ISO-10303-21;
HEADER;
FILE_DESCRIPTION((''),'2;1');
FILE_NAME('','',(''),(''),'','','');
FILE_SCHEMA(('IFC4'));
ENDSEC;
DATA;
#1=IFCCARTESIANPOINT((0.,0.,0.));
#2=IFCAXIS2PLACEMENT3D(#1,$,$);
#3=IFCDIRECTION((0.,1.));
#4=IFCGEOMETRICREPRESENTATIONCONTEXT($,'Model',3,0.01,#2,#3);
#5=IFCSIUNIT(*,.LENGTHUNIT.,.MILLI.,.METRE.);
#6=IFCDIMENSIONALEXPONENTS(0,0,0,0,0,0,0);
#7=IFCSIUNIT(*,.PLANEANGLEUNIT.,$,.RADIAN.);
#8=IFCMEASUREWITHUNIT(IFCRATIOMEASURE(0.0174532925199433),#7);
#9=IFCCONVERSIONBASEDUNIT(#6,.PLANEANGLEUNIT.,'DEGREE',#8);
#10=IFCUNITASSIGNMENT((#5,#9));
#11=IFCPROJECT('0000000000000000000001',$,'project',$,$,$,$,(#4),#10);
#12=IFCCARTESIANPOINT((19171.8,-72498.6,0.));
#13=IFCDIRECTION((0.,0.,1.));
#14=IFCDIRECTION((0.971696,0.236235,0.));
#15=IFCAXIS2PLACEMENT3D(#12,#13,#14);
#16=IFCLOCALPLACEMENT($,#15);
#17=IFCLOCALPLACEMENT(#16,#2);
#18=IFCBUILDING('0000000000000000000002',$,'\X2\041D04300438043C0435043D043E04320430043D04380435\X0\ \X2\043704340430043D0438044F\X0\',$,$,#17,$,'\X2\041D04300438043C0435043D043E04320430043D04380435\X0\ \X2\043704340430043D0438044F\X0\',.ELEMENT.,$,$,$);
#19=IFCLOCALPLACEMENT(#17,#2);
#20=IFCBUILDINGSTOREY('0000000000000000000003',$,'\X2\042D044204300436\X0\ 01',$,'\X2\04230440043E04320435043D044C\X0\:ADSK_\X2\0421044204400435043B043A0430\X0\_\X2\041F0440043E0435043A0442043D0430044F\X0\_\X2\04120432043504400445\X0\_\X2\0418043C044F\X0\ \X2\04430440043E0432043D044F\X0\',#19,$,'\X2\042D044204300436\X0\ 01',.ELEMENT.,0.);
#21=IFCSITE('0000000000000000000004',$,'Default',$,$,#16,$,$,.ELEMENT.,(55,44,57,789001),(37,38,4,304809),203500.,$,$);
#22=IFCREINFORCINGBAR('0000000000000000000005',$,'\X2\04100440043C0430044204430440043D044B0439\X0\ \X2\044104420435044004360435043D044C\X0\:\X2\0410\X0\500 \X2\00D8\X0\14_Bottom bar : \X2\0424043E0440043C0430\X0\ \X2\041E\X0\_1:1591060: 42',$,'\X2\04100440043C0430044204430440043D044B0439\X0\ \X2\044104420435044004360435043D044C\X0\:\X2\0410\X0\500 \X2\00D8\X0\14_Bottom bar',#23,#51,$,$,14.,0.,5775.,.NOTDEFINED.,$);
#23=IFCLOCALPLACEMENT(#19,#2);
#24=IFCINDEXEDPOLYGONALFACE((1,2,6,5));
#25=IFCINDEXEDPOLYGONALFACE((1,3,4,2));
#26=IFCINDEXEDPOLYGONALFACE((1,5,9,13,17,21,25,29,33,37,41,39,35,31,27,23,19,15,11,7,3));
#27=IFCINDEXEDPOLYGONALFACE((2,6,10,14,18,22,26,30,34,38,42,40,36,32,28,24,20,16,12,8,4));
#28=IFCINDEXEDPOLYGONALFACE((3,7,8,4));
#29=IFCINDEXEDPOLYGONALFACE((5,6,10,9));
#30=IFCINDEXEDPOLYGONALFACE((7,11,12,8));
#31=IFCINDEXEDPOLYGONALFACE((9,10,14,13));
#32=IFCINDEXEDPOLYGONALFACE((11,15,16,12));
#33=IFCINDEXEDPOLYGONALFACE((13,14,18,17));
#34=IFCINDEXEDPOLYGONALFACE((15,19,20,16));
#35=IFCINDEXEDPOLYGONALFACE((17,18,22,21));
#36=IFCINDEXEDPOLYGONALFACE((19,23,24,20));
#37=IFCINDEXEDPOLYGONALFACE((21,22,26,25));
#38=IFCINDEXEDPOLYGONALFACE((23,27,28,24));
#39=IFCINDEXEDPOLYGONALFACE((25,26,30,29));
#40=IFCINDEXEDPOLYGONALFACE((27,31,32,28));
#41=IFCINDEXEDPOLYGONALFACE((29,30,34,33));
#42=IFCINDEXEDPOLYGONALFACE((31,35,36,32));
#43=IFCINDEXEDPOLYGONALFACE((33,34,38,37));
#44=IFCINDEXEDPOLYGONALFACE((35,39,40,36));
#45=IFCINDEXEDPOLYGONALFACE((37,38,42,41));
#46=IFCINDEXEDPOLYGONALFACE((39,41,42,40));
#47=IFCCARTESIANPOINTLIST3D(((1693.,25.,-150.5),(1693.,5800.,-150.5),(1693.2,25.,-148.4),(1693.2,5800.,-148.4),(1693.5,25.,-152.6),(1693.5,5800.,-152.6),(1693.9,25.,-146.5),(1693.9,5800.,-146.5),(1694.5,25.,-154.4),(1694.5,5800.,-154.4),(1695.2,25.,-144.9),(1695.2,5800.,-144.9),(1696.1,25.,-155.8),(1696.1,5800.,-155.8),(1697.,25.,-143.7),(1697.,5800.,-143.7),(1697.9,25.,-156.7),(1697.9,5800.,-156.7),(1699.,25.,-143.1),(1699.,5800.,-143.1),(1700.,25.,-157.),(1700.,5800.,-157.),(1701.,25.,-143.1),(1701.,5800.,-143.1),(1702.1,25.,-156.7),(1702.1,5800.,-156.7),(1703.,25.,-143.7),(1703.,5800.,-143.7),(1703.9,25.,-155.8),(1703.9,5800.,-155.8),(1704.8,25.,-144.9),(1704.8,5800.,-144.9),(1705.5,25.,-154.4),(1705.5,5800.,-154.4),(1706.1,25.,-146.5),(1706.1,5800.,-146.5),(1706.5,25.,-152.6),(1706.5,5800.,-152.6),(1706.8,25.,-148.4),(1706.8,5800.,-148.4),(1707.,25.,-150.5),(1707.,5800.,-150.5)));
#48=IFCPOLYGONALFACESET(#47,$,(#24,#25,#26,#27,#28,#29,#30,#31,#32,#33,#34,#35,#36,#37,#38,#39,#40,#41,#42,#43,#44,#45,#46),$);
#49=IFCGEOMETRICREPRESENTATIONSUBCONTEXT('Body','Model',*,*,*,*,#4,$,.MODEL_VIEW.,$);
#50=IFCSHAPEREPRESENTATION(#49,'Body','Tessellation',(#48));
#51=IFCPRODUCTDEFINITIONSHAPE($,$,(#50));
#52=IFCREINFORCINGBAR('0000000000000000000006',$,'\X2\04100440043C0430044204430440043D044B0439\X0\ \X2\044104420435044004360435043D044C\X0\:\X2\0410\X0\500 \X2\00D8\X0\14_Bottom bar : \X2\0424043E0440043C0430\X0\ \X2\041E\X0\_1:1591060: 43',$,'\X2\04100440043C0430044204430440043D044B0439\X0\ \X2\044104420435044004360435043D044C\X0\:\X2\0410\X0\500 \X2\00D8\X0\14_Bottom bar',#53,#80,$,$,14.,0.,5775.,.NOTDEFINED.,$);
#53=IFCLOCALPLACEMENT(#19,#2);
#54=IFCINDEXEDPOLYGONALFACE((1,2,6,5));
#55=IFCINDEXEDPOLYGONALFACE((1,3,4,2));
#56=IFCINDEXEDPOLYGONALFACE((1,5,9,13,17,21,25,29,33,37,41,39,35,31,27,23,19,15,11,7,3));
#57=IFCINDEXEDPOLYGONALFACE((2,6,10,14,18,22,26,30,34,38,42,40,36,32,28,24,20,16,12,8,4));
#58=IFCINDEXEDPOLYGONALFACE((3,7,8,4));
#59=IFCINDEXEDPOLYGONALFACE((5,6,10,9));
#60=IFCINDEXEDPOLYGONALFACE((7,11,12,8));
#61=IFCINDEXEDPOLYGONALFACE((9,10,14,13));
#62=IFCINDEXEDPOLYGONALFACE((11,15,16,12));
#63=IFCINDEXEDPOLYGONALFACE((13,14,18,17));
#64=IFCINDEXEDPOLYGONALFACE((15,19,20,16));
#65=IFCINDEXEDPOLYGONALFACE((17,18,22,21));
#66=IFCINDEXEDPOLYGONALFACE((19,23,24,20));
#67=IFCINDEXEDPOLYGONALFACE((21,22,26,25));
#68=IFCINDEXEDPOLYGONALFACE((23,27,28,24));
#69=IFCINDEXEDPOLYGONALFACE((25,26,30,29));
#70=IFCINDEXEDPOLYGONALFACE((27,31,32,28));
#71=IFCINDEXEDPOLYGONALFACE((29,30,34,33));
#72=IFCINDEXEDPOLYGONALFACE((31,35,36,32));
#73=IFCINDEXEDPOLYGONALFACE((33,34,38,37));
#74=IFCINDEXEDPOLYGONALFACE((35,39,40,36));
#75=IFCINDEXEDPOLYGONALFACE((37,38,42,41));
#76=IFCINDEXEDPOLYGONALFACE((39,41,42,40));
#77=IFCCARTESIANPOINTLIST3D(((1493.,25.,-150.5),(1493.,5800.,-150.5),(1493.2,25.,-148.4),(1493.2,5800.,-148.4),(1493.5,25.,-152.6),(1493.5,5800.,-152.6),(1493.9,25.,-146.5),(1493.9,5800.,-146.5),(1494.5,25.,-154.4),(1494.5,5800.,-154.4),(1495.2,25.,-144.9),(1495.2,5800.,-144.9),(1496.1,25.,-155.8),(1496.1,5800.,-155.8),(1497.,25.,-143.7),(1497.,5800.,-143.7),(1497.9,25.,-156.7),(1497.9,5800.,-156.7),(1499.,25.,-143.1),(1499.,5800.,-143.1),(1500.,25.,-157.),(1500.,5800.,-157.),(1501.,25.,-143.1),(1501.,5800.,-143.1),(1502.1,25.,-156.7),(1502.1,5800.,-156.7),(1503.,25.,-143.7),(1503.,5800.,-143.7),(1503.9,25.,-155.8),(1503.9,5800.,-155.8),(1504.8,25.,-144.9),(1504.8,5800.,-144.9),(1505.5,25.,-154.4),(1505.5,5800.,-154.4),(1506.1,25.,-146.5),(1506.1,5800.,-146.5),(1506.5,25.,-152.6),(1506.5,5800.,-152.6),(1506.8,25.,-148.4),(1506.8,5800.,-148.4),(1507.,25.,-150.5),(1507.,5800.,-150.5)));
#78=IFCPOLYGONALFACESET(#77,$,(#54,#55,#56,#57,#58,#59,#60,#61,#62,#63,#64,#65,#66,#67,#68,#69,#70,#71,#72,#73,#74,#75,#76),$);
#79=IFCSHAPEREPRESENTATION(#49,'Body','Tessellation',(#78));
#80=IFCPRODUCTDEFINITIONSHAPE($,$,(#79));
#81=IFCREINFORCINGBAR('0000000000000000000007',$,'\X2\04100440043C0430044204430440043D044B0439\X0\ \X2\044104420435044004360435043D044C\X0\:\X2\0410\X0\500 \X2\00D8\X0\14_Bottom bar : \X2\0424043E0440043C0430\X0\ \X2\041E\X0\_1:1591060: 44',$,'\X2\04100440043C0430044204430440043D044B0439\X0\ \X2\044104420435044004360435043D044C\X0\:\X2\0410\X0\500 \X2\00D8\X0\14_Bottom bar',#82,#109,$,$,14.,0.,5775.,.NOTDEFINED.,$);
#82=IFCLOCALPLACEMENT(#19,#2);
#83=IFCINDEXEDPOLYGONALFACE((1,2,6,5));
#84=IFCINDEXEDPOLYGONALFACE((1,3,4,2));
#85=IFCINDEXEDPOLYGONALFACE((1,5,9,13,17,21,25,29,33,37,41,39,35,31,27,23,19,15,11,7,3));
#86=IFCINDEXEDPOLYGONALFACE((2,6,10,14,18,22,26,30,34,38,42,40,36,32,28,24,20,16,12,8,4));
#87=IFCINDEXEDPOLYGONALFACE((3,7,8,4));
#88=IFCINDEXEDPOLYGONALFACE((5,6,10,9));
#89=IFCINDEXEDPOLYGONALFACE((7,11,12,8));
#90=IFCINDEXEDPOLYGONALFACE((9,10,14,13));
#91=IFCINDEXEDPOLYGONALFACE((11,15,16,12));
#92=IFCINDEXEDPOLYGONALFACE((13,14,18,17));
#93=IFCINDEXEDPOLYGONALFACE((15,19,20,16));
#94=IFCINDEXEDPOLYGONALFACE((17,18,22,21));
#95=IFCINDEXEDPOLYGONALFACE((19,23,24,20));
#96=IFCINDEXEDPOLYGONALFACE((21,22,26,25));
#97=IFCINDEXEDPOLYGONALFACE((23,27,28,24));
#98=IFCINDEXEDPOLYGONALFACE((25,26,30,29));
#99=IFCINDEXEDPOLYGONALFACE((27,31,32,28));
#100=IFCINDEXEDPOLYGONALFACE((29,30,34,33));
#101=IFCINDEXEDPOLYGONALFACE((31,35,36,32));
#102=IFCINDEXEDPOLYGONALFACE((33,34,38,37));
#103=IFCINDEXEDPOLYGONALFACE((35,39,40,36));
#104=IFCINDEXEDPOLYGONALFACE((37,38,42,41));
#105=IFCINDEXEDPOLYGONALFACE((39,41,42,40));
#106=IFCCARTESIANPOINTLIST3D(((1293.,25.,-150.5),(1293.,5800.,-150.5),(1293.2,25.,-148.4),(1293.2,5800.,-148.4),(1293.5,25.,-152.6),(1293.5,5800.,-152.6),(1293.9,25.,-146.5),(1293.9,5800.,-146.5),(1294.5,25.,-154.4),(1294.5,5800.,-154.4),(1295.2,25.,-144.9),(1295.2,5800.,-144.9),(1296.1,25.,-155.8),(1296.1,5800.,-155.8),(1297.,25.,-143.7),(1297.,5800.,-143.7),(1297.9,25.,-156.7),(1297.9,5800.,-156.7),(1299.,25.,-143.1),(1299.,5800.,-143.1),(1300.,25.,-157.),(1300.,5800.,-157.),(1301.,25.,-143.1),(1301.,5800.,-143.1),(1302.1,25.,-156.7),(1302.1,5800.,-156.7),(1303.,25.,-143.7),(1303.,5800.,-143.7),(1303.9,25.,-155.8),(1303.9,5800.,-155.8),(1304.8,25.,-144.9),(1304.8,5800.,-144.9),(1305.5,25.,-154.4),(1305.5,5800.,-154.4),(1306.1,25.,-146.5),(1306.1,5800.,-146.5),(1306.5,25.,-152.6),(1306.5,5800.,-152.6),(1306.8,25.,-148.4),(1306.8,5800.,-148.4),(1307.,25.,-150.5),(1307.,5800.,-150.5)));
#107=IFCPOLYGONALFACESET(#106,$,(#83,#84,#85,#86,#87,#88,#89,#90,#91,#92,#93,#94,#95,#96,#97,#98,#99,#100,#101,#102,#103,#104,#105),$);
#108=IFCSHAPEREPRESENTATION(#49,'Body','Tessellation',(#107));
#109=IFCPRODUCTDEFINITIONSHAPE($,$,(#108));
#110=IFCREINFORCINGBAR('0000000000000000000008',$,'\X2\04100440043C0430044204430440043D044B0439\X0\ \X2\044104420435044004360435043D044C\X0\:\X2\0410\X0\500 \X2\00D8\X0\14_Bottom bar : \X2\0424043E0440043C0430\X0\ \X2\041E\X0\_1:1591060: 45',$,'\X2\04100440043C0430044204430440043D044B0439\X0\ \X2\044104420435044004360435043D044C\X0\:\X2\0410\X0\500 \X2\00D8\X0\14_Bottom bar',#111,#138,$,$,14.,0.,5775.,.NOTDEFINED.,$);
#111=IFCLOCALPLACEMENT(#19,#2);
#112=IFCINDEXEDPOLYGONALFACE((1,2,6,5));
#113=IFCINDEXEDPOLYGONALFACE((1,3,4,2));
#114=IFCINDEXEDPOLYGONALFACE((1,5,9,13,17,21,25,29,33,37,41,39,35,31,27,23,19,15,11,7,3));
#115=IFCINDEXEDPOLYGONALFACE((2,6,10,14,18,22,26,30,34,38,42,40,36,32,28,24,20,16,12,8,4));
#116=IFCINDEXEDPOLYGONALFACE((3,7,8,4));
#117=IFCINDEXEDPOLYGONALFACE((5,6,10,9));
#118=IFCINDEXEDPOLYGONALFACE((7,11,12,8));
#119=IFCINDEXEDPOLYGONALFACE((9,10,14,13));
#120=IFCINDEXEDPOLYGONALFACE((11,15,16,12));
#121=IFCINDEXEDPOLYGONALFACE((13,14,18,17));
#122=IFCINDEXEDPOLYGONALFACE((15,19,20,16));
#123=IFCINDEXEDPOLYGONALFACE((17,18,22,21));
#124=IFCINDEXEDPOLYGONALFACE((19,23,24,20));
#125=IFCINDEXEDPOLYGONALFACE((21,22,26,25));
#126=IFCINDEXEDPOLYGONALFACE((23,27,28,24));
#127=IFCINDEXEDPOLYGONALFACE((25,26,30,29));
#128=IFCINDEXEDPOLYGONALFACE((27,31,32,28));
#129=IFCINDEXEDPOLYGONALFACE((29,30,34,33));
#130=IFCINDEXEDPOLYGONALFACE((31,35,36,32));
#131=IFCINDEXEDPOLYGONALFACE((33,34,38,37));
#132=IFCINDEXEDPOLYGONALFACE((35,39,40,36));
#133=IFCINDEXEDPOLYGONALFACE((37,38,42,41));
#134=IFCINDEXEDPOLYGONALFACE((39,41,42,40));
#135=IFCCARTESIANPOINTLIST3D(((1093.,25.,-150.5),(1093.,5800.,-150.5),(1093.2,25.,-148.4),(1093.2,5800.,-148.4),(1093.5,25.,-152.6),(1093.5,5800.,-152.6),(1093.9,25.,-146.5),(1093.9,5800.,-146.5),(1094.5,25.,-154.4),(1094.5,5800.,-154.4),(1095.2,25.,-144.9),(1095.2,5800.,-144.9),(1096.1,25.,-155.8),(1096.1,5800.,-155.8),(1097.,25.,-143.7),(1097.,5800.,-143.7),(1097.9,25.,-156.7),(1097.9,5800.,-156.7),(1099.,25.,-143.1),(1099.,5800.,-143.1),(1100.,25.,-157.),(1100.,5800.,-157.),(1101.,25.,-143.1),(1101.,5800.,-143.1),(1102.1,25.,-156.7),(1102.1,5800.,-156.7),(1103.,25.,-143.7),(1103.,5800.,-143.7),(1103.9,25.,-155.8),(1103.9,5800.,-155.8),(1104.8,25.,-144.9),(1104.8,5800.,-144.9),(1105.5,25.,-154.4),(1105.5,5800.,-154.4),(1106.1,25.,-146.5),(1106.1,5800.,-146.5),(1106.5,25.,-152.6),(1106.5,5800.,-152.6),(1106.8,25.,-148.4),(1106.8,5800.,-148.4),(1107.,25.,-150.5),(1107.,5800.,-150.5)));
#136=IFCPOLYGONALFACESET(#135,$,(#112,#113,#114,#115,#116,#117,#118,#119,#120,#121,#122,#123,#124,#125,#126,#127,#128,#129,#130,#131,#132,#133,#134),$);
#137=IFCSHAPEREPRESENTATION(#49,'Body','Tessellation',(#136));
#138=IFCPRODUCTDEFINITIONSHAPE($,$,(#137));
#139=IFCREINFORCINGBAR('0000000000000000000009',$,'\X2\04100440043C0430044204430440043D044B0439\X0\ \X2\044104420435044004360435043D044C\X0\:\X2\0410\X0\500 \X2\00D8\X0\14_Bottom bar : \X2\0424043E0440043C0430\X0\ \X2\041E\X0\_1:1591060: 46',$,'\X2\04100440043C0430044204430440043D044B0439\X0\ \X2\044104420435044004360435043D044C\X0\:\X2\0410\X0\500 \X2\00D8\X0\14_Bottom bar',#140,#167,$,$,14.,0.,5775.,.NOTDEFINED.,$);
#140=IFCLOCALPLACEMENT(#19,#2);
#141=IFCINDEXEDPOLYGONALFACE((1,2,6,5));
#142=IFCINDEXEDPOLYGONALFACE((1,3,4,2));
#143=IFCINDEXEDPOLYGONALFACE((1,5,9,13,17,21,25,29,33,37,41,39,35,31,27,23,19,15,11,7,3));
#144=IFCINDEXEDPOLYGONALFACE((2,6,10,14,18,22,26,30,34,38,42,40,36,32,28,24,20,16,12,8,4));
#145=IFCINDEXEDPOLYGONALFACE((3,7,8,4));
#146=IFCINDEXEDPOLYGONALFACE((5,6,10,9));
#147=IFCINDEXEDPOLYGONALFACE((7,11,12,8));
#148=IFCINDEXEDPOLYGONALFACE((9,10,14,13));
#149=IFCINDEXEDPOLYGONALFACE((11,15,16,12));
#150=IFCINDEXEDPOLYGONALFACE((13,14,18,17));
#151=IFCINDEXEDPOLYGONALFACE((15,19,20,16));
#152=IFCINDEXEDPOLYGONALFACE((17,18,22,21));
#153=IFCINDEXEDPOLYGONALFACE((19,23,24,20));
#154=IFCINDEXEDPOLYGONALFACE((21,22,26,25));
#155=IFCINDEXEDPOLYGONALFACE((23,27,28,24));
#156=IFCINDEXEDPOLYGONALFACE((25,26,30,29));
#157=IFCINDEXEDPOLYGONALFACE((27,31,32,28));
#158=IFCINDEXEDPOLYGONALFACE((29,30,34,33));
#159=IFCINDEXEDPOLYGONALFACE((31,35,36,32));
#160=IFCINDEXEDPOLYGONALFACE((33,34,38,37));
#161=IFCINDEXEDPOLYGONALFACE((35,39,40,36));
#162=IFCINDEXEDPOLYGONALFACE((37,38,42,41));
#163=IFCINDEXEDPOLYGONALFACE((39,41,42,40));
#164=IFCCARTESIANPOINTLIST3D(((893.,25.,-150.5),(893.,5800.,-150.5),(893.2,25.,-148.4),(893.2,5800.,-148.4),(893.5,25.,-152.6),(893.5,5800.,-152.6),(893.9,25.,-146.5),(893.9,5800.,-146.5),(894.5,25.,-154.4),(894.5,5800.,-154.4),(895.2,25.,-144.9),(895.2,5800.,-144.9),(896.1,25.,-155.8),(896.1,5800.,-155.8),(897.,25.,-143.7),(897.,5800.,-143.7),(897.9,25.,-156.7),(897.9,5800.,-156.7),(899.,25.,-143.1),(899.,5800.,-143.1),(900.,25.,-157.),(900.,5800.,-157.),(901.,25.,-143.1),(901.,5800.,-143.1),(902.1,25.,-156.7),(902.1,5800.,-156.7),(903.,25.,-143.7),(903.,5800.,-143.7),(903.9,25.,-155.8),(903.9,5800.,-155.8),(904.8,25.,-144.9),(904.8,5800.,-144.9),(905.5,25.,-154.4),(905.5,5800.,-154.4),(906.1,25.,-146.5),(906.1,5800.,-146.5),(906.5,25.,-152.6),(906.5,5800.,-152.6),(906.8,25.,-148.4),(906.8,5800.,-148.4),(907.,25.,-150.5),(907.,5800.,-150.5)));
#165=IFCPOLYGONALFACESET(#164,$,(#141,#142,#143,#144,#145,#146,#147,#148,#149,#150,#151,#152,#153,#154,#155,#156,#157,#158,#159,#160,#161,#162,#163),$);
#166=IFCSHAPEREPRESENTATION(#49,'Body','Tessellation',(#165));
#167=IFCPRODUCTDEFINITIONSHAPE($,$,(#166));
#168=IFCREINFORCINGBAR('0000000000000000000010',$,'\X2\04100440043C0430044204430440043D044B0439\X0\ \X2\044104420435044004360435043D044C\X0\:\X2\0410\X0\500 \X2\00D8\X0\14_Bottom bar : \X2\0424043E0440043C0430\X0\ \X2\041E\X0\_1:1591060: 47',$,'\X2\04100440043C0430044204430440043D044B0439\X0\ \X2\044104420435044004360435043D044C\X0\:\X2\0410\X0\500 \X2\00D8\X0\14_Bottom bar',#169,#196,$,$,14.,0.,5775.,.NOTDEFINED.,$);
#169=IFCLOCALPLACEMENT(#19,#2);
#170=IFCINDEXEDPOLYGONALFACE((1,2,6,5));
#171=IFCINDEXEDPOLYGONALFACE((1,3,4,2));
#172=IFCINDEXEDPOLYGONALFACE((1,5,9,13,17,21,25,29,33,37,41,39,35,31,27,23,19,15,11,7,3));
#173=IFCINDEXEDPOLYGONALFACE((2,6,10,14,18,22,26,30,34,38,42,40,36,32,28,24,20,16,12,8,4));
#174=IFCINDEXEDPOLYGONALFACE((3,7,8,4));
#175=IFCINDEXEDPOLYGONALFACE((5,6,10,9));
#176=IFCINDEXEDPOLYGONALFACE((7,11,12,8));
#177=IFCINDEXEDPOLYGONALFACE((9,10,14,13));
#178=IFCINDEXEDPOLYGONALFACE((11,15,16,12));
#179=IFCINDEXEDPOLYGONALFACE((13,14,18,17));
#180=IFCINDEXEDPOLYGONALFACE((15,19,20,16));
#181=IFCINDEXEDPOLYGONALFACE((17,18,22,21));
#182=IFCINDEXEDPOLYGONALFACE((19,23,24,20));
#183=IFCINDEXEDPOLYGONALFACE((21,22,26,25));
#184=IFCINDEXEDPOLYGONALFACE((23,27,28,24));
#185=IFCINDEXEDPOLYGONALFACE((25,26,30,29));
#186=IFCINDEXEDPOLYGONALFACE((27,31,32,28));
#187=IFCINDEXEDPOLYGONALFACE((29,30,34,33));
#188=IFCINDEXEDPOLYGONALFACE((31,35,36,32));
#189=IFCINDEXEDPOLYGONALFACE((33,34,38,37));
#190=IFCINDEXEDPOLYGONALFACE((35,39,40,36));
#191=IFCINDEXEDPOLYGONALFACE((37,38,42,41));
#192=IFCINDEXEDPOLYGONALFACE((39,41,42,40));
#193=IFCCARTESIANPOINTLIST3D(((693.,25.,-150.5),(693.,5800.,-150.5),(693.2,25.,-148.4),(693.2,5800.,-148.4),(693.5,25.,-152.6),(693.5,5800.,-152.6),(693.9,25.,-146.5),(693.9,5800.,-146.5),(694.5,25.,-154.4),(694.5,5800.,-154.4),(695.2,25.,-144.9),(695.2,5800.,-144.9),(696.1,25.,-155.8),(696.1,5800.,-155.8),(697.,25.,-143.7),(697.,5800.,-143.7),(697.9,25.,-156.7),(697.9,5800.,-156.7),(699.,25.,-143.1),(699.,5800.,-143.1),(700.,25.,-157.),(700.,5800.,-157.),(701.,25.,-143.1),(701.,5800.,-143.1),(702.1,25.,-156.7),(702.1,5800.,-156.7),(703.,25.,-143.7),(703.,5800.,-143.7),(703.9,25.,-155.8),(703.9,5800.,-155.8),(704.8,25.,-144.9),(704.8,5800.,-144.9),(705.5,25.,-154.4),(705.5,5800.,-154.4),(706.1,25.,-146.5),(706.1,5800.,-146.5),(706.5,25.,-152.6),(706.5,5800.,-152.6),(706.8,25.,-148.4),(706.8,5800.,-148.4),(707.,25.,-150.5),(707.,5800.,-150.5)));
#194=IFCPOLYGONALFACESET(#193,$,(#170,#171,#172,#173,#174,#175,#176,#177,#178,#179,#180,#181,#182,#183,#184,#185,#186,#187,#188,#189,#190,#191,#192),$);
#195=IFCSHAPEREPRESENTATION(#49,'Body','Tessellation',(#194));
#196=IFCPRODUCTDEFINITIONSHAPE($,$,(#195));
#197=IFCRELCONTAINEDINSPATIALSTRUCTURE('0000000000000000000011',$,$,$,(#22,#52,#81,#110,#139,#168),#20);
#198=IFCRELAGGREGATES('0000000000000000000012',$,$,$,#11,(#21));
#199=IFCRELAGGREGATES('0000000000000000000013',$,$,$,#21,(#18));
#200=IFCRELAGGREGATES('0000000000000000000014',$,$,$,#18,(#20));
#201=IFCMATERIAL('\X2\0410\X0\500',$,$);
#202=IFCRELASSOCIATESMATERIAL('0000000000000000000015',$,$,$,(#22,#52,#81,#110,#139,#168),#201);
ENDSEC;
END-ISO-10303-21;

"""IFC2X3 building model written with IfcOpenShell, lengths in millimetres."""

from ifc_helpers import new_model, entity, si_unit, converted_unit, direction, frame, origin, place, context, subcontext, project, spatial, material, element, save


model = new_model("IFC2X3")

# Units and contexts
model_context = context("Model", 3, precision=0.01, world=origin(), true_north=direction((0.0, 1.0)))
body_context = subcontext(model_context, "Body", "Model", "MODEL_VIEW")
ifc_project = project(units=[si_unit("LENGTHUNIT", "METRE", prefix="MILLI"), converted_unit("PLANEANGLEUNIT", "DEGREE", entity("IfcRatioMeasure", 0.0174532925199433), si_unit("PLANEANGLEUNIT", "RADIAN"), dimensions=[0, 0, 0, 0, 0, 0, 0])], contexts=[model_context])

# Site, building, storey
site_placement = place(None, frame((19171.8, -72498.6, 0.0), z_axis=(0.0, 0.0, 1.0), x_axis=(0.971696, 0.236235, 0.0)))
site = spatial("IfcSite", under=ifc_project, at=site_placement, Name="Default", CompositionType="ELEMENT", RefLatitude=(55, 44, 57, 789001), RefLongitude=(37, 38, 4, 304809), RefElevation=203500.0)
building_placement = place(site_placement, origin())
building = spatial("IfcBuilding", under=site, at=building_placement, Name="Наименование здания", LongName="Наименование здания", CompositionType="ELEMENT")
storey_placement = place(building_placement, origin())
storey = spatial("IfcBuildingStorey", under=building, at=storey_placement, Name="Этаж 01", ObjectType="Уровень:ADSK_Стрелка_Проектная_Вверх_Имя уровня", LongName="Этаж 01", CompositionType="ELEMENT", Elevation=0.0)

# Reinforcing bars
ifc_material = material(Name="А500")
placement = place(storey_placement, origin())
element("IfcReinforcingBar", 1, at=placement, inside=storey, material=ifc_material, Name="Арматурный стержень:А500 Ø14_Bottom bar : Форма О_1:1591060: 42", ObjectType="Арматурный стержень:А500 Ø14_Bottom bar", BarLength=5775.0, BarRole="NOTDEFINED", CrossSectionArea=0.0, NominalDiameter=14.0, context=body_context, shape_type="AdvancedSweptSolid", body=[
    entity("IfcSweptDiskSolid", entity("IfcCompositeCurve", [entity("IfcCompositeCurveSegment", "CONTINUOUS", True, entity("IfcPolyline", [entity("IfcCartesianPoint", [1700.0, 5800.0, -150.0]), entity("IfcCartesianPoint", [1700.0, 25.0, -150.0])]))], False), 7.0, None, 0.0, 1.0),
])
element("IfcReinforcingBar", 2, at=placement, inside=storey, material=ifc_material, Name="Арматурный стержень:А500 Ø14_Bottom bar : Форма О_1:1591060: 43", ObjectType="Арматурный стержень:А500 Ø14_Bottom bar", BarLength=5775.0, BarRole="NOTDEFINED", CrossSectionArea=0.0, NominalDiameter=14.0, context=body_context, shape_type="AdvancedSweptSolid", body=[
    entity("IfcSweptDiskSolid", entity("IfcCompositeCurve", [entity("IfcCompositeCurveSegment", "CONTINUOUS", True, entity("IfcPolyline", [entity("IfcCartesianPoint", [1500.0, 5800.0, -150.0]), entity("IfcCartesianPoint", [1500.0, 25.0, -150.0])]))], False), 7.0, None, 0.0, 1.0),
])
element("IfcReinforcingBar", 3, at=placement, inside=storey, material=ifc_material, Name="Арматурный стержень:А500 Ø14_Bottom bar : Форма О_1:1591060: 44", ObjectType="Арматурный стержень:А500 Ø14_Bottom bar", BarLength=5775.0, BarRole="NOTDEFINED", CrossSectionArea=0.0, NominalDiameter=14.0, context=body_context, shape_type="AdvancedSweptSolid", body=[
    entity("IfcSweptDiskSolid", entity("IfcCompositeCurve", [entity("IfcCompositeCurveSegment", "CONTINUOUS", True, entity("IfcPolyline", [entity("IfcCartesianPoint", [1300.0, 5800.0, -150.0]), entity("IfcCartesianPoint", [1300.0, 25.0, -150.0])]))], False), 7.0, None, 0.0, 1.0),
])
element("IfcReinforcingBar", 4, at=placement, inside=storey, material=ifc_material, Name="Арматурный стержень:А500 Ø14_Bottom bar : Форма О_1:1591060: 45", ObjectType="Арматурный стержень:А500 Ø14_Bottom bar", BarLength=5775.0, BarRole="NOTDEFINED", CrossSectionArea=0.0, NominalDiameter=14.0, context=body_context, shape_type="AdvancedSweptSolid", body=[
    entity("IfcSweptDiskSolid", entity("IfcCompositeCurve", [entity("IfcCompositeCurveSegment", "CONTINUOUS", True, entity("IfcPolyline", [entity("IfcCartesianPoint", [1100.0, 5800.0, -150.0]), entity("IfcCartesianPoint", [1100.0, 25.0, -150.0])]))], False), 7.0, None, 0.0, 1.0),
])
element("IfcReinforcingBar", 5, at=placement, inside=storey, material=ifc_material, Name="Арматурный стержень:А500 Ø14_Bottom bar : Форма О_1:1591060: 46", ObjectType="Арматурный стержень:А500 Ø14_Bottom bar", BarLength=5775.0, BarRole="NOTDEFINED", CrossSectionArea=0.0, NominalDiameter=14.0, context=body_context, shape_type="AdvancedSweptSolid", body=[
    entity("IfcSweptDiskSolid", entity("IfcCompositeCurve", [entity("IfcCompositeCurveSegment", "CONTINUOUS", True, entity("IfcPolyline", [entity("IfcCartesianPoint", [900.0, 5800.0, -150.0]), entity("IfcCartesianPoint", [900.0, 25.0, -150.0])]))], False), 7.0, None, 0.0, 1.0),
])
element("IfcReinforcingBar", 6, at=placement, inside=storey, material=ifc_material, Name="Арматурный стержень:А500 Ø14_Bottom bar : Форма О_1:1591060: 47", ObjectType="Арматурный стержень:А500 Ø14_Bottom bar", BarLength=5775.0, BarRole="NOTDEFINED", CrossSectionArea=0.0, NominalDiameter=14.0, context=body_context, shape_type="AdvancedSweptSolid", body=[
    entity("IfcSweptDiskSolid", entity("IfcCompositeCurve", [entity("IfcCompositeCurveSegment", "CONTINUOUS", True, entity("IfcPolyline", [entity("IfcCartesianPoint", [700.0, 5800.0, -150.0]), entity("IfcCartesianPoint", [700.0, 25.0, -150.0])]))], False), 7.0, None, 0.0, 1.0),
])

save(model, "model.ifc")
